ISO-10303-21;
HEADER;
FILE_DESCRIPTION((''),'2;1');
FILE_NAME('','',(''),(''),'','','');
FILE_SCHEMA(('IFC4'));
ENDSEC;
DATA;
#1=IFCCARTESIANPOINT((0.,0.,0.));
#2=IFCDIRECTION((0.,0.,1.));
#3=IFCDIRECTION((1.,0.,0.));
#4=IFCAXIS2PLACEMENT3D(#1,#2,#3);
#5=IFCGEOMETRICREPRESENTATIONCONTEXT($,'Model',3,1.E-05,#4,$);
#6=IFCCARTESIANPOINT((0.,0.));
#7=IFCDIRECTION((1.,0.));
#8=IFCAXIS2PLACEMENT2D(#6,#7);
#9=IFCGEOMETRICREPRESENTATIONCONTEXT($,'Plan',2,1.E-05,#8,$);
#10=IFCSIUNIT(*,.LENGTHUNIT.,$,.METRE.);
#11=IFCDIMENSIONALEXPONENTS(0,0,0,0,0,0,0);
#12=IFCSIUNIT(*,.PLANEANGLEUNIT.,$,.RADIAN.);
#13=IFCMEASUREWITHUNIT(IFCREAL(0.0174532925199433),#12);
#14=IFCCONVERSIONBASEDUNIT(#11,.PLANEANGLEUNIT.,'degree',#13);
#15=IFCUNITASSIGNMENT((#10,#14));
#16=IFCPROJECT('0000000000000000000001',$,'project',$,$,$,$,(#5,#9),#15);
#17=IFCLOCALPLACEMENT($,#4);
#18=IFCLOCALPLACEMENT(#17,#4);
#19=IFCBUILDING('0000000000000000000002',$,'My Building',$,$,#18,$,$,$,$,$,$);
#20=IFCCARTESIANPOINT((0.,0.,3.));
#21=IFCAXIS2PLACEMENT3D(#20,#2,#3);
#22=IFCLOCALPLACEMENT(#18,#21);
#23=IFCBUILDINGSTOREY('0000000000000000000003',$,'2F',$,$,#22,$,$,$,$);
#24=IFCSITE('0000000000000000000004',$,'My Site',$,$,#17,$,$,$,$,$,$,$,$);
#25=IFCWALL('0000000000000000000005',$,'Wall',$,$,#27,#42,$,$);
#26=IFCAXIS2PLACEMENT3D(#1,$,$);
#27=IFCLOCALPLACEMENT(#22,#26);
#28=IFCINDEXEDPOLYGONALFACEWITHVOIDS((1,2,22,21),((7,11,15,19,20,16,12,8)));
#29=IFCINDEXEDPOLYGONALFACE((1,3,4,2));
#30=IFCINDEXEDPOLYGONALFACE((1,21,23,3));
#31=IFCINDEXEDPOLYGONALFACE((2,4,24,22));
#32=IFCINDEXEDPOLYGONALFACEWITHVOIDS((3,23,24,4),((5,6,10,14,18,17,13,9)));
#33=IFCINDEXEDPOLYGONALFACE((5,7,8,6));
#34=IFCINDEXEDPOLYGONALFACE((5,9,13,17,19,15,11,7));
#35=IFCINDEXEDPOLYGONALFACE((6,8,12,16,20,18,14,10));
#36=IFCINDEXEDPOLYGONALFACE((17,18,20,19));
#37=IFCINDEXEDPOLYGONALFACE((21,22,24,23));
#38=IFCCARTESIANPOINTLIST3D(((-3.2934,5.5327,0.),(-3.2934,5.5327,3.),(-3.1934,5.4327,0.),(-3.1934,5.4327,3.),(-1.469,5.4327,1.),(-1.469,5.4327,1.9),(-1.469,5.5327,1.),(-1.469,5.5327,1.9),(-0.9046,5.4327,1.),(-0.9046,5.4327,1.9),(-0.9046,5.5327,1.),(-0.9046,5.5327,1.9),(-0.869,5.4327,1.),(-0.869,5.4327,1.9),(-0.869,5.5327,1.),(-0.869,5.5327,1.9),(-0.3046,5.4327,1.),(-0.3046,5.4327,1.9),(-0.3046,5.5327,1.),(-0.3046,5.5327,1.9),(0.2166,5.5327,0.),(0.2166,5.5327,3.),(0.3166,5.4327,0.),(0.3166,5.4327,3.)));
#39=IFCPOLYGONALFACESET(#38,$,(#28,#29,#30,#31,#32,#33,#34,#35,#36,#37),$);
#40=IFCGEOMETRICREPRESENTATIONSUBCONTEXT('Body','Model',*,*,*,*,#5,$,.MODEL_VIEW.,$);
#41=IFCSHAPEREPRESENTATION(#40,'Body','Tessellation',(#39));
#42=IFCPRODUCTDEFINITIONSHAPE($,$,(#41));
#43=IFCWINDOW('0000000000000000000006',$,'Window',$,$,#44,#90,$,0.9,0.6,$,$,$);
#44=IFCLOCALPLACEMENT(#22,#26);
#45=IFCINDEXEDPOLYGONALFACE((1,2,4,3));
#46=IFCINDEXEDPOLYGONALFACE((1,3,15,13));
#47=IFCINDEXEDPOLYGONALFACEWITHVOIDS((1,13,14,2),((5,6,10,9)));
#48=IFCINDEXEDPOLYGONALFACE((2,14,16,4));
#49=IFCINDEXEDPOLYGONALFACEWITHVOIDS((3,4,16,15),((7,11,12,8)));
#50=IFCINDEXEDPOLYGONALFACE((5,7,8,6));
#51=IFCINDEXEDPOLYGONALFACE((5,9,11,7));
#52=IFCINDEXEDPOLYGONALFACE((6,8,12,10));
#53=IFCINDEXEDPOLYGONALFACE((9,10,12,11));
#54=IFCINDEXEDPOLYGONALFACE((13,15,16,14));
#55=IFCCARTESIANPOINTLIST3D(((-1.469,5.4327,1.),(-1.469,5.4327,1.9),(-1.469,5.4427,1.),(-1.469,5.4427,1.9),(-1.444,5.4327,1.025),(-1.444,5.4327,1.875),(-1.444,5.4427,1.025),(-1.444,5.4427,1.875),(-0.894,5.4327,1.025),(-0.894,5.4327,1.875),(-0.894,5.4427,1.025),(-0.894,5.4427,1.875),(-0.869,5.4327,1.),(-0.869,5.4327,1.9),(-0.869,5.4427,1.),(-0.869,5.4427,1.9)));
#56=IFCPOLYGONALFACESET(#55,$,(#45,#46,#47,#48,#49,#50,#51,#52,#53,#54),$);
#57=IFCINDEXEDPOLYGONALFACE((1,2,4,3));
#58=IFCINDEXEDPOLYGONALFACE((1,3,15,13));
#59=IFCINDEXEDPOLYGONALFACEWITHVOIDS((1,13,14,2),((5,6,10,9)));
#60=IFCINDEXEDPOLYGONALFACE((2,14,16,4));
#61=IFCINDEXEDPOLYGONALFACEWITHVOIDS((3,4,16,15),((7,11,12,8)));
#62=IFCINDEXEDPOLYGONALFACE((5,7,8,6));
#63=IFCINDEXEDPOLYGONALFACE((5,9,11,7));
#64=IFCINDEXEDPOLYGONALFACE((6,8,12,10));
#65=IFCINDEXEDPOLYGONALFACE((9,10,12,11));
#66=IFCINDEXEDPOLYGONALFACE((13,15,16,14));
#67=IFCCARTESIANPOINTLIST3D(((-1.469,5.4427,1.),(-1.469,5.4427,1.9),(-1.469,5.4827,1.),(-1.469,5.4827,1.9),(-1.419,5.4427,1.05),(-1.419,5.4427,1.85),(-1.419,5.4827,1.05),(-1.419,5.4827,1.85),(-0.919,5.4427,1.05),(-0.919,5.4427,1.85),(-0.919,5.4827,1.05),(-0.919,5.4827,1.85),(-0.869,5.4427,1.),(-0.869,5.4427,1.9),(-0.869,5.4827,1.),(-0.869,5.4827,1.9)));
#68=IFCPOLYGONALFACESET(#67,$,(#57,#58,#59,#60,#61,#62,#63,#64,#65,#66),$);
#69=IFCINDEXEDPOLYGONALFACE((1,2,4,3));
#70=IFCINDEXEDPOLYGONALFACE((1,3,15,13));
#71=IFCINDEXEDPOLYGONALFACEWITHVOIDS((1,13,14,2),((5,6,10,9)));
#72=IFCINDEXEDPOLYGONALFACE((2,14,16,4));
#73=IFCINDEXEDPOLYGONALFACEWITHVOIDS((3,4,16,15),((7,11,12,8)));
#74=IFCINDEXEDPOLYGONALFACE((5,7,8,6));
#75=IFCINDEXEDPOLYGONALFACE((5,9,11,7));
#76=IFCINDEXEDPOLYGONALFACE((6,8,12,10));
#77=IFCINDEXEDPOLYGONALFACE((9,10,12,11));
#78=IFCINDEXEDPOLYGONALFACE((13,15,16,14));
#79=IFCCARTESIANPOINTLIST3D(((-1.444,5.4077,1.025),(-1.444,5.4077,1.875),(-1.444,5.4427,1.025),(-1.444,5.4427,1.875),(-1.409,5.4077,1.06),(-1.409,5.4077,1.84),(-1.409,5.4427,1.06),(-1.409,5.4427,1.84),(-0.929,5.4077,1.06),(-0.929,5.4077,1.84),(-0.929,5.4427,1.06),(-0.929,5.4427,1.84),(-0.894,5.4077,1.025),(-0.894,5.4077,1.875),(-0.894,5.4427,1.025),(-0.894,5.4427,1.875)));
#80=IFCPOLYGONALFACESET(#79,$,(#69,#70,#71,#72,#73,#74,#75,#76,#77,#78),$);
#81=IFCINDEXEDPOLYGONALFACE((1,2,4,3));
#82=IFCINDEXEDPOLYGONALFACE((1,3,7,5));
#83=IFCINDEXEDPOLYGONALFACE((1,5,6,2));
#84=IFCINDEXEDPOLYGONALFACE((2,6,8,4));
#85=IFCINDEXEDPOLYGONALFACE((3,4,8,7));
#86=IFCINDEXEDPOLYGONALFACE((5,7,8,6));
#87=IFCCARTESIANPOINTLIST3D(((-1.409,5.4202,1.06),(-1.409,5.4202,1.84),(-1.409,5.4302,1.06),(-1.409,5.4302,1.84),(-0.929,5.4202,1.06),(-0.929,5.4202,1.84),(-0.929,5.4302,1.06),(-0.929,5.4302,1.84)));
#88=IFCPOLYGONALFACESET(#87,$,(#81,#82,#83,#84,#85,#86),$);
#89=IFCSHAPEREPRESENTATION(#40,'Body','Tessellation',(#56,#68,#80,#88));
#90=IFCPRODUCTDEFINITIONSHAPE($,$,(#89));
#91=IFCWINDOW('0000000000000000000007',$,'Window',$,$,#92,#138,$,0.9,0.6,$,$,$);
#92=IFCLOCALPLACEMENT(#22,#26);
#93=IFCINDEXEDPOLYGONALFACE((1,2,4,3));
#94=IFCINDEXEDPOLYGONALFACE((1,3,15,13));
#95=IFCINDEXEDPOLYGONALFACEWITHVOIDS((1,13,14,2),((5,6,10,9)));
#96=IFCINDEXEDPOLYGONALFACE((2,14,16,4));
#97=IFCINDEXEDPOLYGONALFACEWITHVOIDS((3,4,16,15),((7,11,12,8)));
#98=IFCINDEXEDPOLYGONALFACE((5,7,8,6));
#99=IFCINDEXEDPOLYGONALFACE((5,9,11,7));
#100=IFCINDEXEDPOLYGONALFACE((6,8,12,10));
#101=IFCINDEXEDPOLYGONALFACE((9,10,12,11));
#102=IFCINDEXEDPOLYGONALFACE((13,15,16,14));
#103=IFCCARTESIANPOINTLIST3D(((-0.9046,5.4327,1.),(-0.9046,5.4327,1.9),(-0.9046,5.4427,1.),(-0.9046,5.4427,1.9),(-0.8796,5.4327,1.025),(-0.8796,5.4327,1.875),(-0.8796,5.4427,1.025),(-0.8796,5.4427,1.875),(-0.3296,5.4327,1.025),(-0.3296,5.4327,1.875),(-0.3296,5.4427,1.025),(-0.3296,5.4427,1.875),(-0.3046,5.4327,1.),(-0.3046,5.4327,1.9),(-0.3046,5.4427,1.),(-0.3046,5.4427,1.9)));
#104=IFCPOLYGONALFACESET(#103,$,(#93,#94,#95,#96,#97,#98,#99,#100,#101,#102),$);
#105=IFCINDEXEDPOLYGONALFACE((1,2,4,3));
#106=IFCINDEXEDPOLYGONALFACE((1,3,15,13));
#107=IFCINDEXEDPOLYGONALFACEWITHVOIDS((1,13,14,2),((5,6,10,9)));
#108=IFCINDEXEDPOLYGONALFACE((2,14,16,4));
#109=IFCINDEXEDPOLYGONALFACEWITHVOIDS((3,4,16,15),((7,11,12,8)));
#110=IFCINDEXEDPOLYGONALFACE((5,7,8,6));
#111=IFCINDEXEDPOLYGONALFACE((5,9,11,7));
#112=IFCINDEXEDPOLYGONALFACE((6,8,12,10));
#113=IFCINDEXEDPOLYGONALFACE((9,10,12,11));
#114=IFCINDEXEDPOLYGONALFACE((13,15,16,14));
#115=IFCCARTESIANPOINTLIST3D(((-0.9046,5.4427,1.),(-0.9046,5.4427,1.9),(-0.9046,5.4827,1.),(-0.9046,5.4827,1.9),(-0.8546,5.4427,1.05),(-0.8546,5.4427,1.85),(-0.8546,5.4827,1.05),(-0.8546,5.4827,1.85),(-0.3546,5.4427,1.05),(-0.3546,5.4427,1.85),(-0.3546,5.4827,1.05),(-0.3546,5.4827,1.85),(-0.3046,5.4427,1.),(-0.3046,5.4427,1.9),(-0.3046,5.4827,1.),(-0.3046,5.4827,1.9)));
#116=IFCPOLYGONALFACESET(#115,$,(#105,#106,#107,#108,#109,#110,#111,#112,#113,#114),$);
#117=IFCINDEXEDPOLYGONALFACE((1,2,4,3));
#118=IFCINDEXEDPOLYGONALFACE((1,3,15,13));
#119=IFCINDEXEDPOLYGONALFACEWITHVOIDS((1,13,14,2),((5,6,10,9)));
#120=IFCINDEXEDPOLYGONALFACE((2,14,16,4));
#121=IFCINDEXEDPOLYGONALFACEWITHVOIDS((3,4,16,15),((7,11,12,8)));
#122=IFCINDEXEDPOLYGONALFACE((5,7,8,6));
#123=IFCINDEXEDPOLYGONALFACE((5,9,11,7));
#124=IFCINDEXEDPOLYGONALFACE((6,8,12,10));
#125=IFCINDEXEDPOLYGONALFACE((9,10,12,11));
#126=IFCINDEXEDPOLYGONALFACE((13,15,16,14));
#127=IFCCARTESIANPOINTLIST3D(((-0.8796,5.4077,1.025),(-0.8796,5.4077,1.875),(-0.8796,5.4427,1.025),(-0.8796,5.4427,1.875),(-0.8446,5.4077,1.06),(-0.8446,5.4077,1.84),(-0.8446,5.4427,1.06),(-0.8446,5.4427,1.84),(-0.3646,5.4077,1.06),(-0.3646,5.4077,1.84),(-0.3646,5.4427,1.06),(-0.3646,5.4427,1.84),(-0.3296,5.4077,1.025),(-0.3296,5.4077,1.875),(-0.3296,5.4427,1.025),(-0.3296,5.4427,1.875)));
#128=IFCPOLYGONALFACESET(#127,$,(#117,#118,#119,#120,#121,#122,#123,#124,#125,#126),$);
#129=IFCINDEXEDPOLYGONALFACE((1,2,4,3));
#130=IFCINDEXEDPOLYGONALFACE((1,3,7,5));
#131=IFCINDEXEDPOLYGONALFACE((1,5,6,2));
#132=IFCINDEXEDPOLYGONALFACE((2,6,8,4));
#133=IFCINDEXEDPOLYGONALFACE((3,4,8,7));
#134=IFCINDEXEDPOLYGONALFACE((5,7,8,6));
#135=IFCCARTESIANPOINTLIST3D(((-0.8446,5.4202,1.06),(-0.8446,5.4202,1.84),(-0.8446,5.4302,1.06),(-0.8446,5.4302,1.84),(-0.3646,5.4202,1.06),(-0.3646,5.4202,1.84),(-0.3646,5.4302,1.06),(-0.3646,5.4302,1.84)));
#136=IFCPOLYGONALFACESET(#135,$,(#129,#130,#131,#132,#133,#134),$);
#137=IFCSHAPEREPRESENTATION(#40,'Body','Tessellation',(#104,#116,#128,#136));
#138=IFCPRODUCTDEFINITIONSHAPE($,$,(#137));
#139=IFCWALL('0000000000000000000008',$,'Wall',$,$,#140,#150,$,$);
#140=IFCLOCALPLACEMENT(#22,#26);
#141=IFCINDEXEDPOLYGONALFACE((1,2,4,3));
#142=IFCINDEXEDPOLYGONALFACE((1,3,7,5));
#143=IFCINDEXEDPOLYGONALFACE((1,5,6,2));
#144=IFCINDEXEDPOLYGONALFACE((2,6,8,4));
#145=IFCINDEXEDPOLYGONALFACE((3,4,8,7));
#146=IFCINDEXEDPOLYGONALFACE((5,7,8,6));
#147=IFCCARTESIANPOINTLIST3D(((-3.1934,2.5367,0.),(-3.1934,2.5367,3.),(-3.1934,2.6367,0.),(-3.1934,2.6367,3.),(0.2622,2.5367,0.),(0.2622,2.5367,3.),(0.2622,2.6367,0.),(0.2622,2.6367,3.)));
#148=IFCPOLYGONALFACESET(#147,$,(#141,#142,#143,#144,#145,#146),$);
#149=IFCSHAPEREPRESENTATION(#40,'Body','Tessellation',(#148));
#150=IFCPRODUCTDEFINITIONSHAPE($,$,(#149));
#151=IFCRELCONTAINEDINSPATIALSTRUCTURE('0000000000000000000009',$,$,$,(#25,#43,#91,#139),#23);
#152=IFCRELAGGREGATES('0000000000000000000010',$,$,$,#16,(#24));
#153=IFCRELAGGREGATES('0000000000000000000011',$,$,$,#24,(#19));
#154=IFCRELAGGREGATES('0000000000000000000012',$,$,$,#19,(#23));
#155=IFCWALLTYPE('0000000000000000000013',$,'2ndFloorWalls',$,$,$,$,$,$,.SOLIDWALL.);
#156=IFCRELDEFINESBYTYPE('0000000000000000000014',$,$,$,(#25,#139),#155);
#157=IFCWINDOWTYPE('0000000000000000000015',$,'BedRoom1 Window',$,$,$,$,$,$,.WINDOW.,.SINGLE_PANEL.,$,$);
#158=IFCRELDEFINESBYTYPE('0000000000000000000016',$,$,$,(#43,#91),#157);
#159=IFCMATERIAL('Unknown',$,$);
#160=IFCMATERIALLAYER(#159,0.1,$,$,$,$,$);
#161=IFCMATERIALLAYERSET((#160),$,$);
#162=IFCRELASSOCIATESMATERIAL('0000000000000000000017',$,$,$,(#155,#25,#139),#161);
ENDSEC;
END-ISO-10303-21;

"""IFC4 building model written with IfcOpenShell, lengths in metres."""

from ifc_helpers import new_model, entity, si_unit, converted_unit, frame, origin_with_axes, origin_2d_with_axis, place, context, subcontext, project, spatial, line, indexed_curve, outline, extrude, shape, source, transform, mapped, material, layer, layer_set, layer_usage, type_object, type_shapes, element, fill, save


model = new_model("IFC4")

# Units and contexts
model_context = context("Model", 3, precision=1e-05, world=origin_with_axes())
plan_context = context("Plan", 2, precision=1e-05, world=origin_2d_with_axis())
body_context_1 = subcontext(model_context, "Body", "Model", "MODEL_VIEW")
body_context_2 = subcontext(plan_context, "Body", "Plan", "PLAN_VIEW")
ifc_project = project(units=[si_unit("LENGTHUNIT", "METRE"), converted_unit("PLANEANGLEUNIT", "degree", entity("IfcReal", 0.0174532925199433), si_unit("PLANEANGLEUNIT", "RADIAN"), dimensions=[0, 0, 0, 0, 0, 0, 0])], contexts=[model_context, plan_context])

# Site, building, storey
site_placement = place(None, origin_with_axes())
site = spatial("IfcSite", under=ifc_project, at=site_placement, Name="My Site")
building_placement = place(site_placement, origin_with_axes())
building = spatial("IfcBuilding", under=site, at=building_placement, Name="My Building")
storey_placement = place(building_placement, frame((0.0, 0.0, 3.0), z_axis=(0.0, 0.0, 1.0), x_axis=(1.0, 0.0, 0.0)))
storey = spatial("IfcBuildingStorey", under=building, at=storey_placement, Name="2F")

# Shared definitions
ifc_material = material(Name="Unknown")

# Shared definitions
ifc_layer_1 = layer(ifc_material, 0.1)
ifc_layer_set_1 = layer_set([ifc_layer_1])
wall_type = type_object("IfcWallType", Name="2ndFloorWalls", PredefinedType="SOLIDWALL", material=ifc_layer_set_1)

# Wall, openings, windows
ifc_layer_usage_1 = layer_usage(ifc_layer_set_1, "AXIS2", "POSITIVE", 0.0)
wall_1_placement = place(storey_placement, frame((0.2166, 5.5327, 0.0), z_axis=(0.0, 0.0, 1.0), x_axis=(-1.0, 0.0, 0.0)))
wall_1 = element("IfcWall", 1, at=wall_1_placement, inside=storey, type_object=wall_type, material=ifc_layer_usage_1, Name="Wall", context=body_context_1, shape_type="SweptSolid", body=[
    extrude(outline(indexed_curve([(0.0, 0.0), (-0.1, 0.1), (3.41, 0.1), (3.51, 0.0)], segments=[line(1, 2, 3, 4, 1)])), origin_with_axes(), (0.0, 0.0, 1.0), 3.0),
])
shared_shape_1 = source(origin_with_axes(), body_context_1, "Body", "SweptSolid", [
    extrude(outline(indexed_curve([(0.0, 0.0), (0.6, 0.0), (0.6, 0.9), (0.0, 0.9)], segments=[line(1, 2, 3, 4, 1)])), frame((0.0, -0.6, 0.0), z_axis=(0.0, -1.0, 0.0), x_axis=(1.0, 0.0, 0.0)), (0.0, 0.0, -1.0), 1.2),
])
opening_1_placement = place(wall_1_placement, frame((1.0856, 0.0, 1.0), z_axis=(0.0, 0.0, 1.0), x_axis=(1.0, 0.0, 0.0)))
opening_1 = element("IfcOpeningElement", 2, at=opening_1_placement, cuts=wall_1, PredefinedType="OPENING", context=body_context_1, shape_type="MappedRepresentation", body=[
    mapped(shared_shape_1, transform((0.0, 0.0, 0.0), x_axis=(1.0, 0.0, 0.0), y_axis=(0.0, 1.0, 0.0), z_axis=(0.0, 0.0, 1.0), scale=1.0)),
])
opening_2_placement = place(wall_1_placement, frame((0.5212, 0.0, 1.0), z_axis=(0.0, 0.0, 1.0), x_axis=(1.0, 0.0, 0.0)))
opening_2 = element("IfcOpeningElement", 3, at=opening_2_placement, cuts=wall_1, PredefinedType="OPENING", context=body_context_1, shape_type="MappedRepresentation", body=[
    mapped(shared_shape_1, transform((0.0, 0.0, 0.0), x_axis=(1.0, 0.0, 0.0), y_axis=(0.0, 1.0, 0.0), z_axis=(0.0, 0.0, 1.0), scale=1.0)),
])
window_type_1 = type_object("IfcWindowType", Name="BedRoom1 Window", PartitioningType="SINGLE_PANEL", PredefinedType="WINDOW")
shared_shape_2 = source(origin_with_axes(), body_context_1, "Body", "SweptSolid", [
    extrude(outline(indexed_curve([(0.0, 0.0), (0.6, 0.0), (0.6, 0.9), (0.0, 0.9)], segments=[line(1, 2, 3, 4, 1)]), holes=[indexed_curve([(0.025, 0.025), (0.575, 0.025), (0.575, 0.875), (0.025, 0.875)], segments=[line(1, 2, 3, 4, 1)])]), frame((0.0, 0.09, 0.0), z_axis=(0.0, -1.0, 0.0), x_axis=(1.0, 0.0, 0.0)), (0.0, 0.0, -1.0), 0.01),
    extrude(outline(indexed_curve([(0.0, 0.0), (0.6, 0.0), (0.6, 0.9), (0.0, 0.9)], segments=[line(1, 2, 3, 4, 1)]), holes=[indexed_curve([(0.05, 0.05), (0.55, 0.05), (0.55, 0.85), (0.05, 0.85)], segments=[line(1, 2, 3, 4, 1)])]), frame((0.0, 0.05, 0.0), z_axis=(0.0, -1.0, 0.0), x_axis=(1.0, 0.0, 0.0)), (0.0, 0.0, -1.0), 0.04),
    extrude(outline(indexed_curve([(0.0, 0.0), (0.55, 0.0), (0.55, 0.85), (0.0, 0.85)], segments=[line(1, 2, 3, 4, 1)]), holes=[indexed_curve([(0.035, 0.035), (0.515, 0.035), (0.515, 0.815), (0.035, 0.815)], segments=[line(1, 2, 3, 4, 1)])]), frame((0.025, 0.09, 0.025), z_axis=(0.0, -1.0, 0.0), x_axis=(1.0, 0.0, 0.0)), (0.0, 0.0, -1.0), 0.035),
    extrude(outline(indexed_curve([(0.035, 0.035), (0.515, 0.035), (0.515, 0.815), (0.035, 0.815)], segments=[line(1, 2, 3, 4, 1)])), frame((0.025, 0.1025, 0.025), z_axis=(0.0, -1.0, 0.0), x_axis=(1.0, 0.0, 0.0)), (0.0, 0.0, -1.0), 0.01),
])
shared_shape_3 = source(origin_with_axes(), body_context_2, "Body", "Curve2D", [
    entity("IfcIndexedPolyCurve", entity("IfcCartesianPointList2D", [[0.05, 0.05], [0.55, 0.05]])),
    entity("IfcIndexedPolyCurve", entity("IfcCartesianPointList2D", [[0.0, 0.1], [0.025, 0.1], [0.025, 0.09], [0.05, 0.09], [0.05, 0.05], [0.0, 0.05]]), [entity("IfcLineIndex", [1, 2, 3, 4, 5, 6, 1])]),
    entity("IfcIndexedPolyCurve", entity("IfcCartesianPointList2D", [[0.6, 0.1], [0.575, 0.1], [0.575, 0.09], [0.55, 0.09], [0.55, 0.05], [0.6, 0.05]]), [entity("IfcLineIndex", [1, 2, 3, 4, 5, 6, 1])]),
    entity("IfcIndexedPolyCurve", entity("IfcCartesianPointList2D", [[0.025, 0.09], [0.06, 0.09], [0.06, 0.125], [0.025, 0.125]]), [entity("IfcLineIndex", [1, 2, 3, 4, 1])]),
    entity("IfcIndexedPolyCurve", entity("IfcCartesianPointList2D", [[0.575, 0.09], [0.54, 0.09], [0.54, 0.125], [0.575, 0.125]]), [entity("IfcLineIndex", [1, 2, 3, 4, 1])]),
    entity("IfcIndexedPolyCurve", entity("IfcCartesianPointList2D", [[0.06, 0.09], [0.54, 0.09]])),
    entity("IfcIndexedPolyCurve", entity("IfcCartesianPointList2D", [[0.06, 0.125], [0.54, 0.125]])),
    entity("IfcIndexedPolyCurve", entity("IfcCartesianPointList2D", [[0.06, 0.1075], [0.54, 0.1075]])),
])
type_shapes(window_type_1, [shared_shape_2, shared_shape_3])
window_1_placement = place(opening_1_placement, origin_with_axes())
window_1 = element("IfcWindow", 4, at=window_1_placement, inside=storey, type_object=window_type_1, Name="Window", OverallHeight=0.9, OverallWidth=0.6, shapes=[
    shape(body_context_1, "Body", "MappedRepresentation", [mapped(shared_shape_2, transform((0.0, 0.0, 0.0), x_axis=(1.0, 0.0, 0.0), y_axis=(0.0, 1.0, 0.0), z_axis=(0.0, 0.0, 1.0), scale=1.0))]),
    shape(body_context_2, "Body", "MappedRepresentation", [mapped(shared_shape_3, transform((0.0, 0.0, 0.0), x_axis=(1.0, 0.0, 0.0), y_axis=(0.0, 1.0, 0.0), z_axis=(0.0, 0.0, 1.0), scale=1.0))]),
])
fill(opening_1, window_1)
window_2_placement = place(opening_2_placement, origin_with_axes())
window_2 = element("IfcWindow", 5, at=window_2_placement, inside=storey, type_object=window_type_1, Name="Window", OverallHeight=0.9, OverallWidth=0.6, shapes=[
    shape(body_context_1, "Body", "MappedRepresentation", [mapped(shared_shape_2, transform((0.0, 0.0, 0.0), x_axis=(1.0, 0.0, 0.0), y_axis=(0.0, 1.0, 0.0), z_axis=(0.0, 0.0, 1.0), scale=1.0))]),
    shape(body_context_2, "Body", "MappedRepresentation", [mapped(shared_shape_3, transform((0.0, 0.0, 0.0), x_axis=(1.0, 0.0, 0.0), y_axis=(0.0, 1.0, 0.0), z_axis=(0.0, 0.0, 1.0), scale=1.0))]),
])
fill(opening_2, window_2)

# Wall
ifc_layer_usage_2 = layer_usage(ifc_layer_set_1, "AXIS2", "POSITIVE", 0.0)
wall_2_placement = place(storey_placement, frame((-3.1934, 2.5367, 0.0), z_axis=(0.0, 0.0, 1.0), x_axis=(1.0, 0.000002, 0.0)))
element("IfcWall", 6, at=wall_2_placement, inside=storey, type_object=wall_type, material=ifc_layer_usage_2, Name="Wall", context=body_context_1, shape_type="SweptSolid", body=[
    extrude(outline(indexed_curve([(0.0, 0.0), (0.0, 0.1), (3.4556, 0.1), (3.4556, 0.0)], segments=[line(1, 2, 3, 4, 1)])), origin_with_axes(), (0.0, 0.0, 1.0), 3.0),
])

save(model, "model.ifc")
